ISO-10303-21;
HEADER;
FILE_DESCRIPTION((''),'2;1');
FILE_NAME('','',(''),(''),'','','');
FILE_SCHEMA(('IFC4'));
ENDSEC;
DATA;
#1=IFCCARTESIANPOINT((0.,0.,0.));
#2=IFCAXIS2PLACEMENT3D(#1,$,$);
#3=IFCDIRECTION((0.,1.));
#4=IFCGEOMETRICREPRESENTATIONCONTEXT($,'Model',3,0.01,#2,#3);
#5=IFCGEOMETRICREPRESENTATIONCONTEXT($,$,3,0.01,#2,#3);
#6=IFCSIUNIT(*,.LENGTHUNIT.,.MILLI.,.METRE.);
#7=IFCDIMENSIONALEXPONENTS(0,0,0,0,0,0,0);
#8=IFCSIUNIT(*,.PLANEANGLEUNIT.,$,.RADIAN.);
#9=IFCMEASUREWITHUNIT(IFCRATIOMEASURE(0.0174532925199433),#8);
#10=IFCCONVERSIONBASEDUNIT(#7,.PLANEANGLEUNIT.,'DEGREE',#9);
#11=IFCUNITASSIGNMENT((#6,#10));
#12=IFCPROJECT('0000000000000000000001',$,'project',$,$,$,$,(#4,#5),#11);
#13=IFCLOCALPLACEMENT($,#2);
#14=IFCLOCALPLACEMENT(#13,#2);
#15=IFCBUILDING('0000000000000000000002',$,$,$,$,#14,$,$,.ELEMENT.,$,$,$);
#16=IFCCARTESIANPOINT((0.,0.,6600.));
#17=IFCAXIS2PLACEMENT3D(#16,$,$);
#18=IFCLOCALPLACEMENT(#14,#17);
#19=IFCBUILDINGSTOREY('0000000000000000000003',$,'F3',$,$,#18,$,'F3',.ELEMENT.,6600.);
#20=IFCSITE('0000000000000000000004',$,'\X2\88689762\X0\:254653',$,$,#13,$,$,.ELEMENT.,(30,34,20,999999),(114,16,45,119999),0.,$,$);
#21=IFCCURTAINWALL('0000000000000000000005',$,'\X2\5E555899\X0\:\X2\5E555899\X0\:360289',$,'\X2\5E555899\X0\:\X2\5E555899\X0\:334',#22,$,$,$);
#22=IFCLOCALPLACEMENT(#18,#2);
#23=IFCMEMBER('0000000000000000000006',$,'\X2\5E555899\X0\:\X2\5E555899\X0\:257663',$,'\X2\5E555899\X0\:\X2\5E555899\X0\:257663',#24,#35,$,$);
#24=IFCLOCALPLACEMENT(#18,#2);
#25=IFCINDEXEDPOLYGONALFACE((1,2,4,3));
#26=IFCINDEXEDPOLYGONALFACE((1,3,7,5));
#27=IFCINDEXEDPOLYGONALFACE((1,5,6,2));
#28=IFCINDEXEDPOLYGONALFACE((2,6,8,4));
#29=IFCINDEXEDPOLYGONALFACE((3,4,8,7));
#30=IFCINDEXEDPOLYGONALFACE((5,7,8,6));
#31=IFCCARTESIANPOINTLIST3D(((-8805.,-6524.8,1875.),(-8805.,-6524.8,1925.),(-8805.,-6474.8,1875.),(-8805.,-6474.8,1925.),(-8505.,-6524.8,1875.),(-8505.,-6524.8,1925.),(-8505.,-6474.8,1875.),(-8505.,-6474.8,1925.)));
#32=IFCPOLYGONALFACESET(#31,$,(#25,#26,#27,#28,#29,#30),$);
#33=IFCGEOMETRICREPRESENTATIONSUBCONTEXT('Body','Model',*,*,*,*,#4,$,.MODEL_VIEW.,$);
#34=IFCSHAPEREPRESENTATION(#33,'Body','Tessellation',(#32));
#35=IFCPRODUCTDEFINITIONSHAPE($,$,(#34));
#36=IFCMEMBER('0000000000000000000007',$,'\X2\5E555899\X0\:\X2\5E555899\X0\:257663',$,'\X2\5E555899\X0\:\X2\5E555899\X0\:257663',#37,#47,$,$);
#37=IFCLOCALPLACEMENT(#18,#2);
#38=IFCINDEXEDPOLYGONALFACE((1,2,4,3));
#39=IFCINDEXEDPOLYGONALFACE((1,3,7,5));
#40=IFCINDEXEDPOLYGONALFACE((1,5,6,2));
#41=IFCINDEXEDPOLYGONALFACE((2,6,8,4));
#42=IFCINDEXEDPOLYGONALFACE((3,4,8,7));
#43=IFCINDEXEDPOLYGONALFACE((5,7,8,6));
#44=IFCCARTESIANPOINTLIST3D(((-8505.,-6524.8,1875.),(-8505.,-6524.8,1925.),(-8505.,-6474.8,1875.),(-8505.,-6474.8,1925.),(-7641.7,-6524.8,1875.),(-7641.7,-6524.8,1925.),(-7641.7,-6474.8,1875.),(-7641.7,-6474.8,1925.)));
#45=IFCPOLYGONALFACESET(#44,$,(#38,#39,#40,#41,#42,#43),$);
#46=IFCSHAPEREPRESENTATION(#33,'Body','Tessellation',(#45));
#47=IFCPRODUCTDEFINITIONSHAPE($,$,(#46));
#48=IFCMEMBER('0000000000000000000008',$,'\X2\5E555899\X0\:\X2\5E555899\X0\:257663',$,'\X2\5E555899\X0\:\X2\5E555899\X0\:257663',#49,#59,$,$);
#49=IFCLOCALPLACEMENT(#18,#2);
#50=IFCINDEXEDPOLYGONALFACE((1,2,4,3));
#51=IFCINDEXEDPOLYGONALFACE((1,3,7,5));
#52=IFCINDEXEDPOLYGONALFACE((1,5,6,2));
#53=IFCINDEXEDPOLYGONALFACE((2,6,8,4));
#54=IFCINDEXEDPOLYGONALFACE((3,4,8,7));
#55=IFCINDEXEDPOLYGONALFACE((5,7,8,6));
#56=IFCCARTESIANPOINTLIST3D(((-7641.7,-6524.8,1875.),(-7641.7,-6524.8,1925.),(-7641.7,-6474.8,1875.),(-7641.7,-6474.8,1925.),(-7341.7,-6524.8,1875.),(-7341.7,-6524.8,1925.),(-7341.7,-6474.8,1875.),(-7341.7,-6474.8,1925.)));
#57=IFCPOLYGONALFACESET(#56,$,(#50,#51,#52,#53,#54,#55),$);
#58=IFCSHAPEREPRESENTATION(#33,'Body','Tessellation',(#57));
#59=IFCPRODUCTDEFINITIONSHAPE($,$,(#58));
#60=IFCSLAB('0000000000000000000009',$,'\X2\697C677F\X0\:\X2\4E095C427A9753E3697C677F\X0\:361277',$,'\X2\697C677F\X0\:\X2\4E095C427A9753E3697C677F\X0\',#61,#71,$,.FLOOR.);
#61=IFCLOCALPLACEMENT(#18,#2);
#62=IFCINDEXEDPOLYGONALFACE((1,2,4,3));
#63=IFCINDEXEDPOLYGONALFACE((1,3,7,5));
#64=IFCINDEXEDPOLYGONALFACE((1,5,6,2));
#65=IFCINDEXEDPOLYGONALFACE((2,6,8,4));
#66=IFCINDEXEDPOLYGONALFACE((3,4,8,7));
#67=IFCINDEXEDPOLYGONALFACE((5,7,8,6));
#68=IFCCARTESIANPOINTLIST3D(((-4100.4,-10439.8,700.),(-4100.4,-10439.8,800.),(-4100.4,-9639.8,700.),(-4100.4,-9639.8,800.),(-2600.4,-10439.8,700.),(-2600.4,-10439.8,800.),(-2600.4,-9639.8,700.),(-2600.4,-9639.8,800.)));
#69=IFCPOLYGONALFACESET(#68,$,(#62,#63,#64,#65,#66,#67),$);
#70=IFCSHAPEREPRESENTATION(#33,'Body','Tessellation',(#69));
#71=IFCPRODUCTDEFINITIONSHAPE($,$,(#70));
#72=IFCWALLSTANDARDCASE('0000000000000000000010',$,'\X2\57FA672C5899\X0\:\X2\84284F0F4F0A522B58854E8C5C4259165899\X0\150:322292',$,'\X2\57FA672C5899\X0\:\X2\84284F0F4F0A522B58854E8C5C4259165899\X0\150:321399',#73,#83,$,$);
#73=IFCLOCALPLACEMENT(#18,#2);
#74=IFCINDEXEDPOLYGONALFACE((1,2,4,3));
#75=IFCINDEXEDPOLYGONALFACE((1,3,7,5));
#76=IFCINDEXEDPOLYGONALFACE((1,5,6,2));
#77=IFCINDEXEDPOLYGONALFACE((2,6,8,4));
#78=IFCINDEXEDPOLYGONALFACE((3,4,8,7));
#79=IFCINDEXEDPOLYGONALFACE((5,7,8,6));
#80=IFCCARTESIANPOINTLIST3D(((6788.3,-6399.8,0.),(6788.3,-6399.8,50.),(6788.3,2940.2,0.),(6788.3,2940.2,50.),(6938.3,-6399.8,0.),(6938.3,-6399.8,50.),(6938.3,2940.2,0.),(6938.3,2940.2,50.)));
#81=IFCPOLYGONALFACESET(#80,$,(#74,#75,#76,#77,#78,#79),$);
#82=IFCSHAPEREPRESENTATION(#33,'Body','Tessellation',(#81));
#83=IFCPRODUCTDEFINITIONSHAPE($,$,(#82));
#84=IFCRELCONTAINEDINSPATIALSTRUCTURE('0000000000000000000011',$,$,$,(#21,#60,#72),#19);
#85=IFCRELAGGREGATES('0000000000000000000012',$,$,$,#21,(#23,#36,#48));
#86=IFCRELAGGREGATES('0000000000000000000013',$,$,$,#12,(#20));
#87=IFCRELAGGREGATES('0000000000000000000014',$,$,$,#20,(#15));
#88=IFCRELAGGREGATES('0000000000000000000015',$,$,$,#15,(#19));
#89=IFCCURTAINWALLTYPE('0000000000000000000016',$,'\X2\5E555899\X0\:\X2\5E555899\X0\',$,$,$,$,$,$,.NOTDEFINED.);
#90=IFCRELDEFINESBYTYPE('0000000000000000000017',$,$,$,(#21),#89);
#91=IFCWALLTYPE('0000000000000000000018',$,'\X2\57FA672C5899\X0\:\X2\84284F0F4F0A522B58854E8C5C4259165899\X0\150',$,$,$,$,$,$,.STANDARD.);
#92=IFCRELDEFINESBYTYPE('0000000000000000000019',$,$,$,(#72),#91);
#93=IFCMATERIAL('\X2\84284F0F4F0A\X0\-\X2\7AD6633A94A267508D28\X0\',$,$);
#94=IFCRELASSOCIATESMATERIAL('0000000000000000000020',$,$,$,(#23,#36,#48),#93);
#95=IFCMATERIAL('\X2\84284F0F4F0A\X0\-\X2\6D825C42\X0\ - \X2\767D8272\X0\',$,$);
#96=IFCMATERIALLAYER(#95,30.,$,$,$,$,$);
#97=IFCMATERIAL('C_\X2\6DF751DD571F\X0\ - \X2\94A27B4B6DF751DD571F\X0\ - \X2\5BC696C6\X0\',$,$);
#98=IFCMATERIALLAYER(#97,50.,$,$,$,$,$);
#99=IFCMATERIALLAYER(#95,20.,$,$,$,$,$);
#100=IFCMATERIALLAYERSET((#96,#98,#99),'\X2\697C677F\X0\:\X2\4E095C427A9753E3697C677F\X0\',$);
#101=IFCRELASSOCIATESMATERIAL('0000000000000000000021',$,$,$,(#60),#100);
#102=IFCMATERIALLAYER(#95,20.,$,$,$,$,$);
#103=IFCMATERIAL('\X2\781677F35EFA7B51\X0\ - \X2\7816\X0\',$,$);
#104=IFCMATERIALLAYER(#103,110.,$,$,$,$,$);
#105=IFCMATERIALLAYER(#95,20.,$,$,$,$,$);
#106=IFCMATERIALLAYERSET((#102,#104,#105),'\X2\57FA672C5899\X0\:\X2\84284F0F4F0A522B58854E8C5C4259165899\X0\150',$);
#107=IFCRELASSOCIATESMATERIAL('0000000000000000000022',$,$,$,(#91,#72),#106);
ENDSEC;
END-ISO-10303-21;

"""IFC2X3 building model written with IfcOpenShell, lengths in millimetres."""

from ifc_helpers import new_model, entity, si_unit, converted_unit, direction, frame, frame_2d, origin, origin_2d_with_axis, place, context, subcontext, project, spatial, rectangle, extrude, material, layer, layer_set, layer_usage, type_object, element, aggregate, save


model = new_model("IFC2X3")

# Units and contexts
model_context = context("Model", 3, precision=0.01, world=origin(), true_north=direction((0.0, 1.0)))
context_of_model = context(None, 3, precision=0.01, world=origin(), true_north=direction((0.0, 1.0)))
body_context = subcontext(model_context, "Body", "Model", "MODEL_VIEW")
ifc_project = project(units=[si_unit("LENGTHUNIT", "METRE", prefix="MILLI"), converted_unit("PLANEANGLEUNIT", "DEGREE", entity("IfcRatioMeasure", 0.0174532925199433), si_unit("PLANEANGLEUNIT", "RADIAN"), dimensions=[0, 0, 0, 0, 0, 0, 0])], contexts=[model_context, context_of_model])

# Site, building, storey
site_placement = place(None, origin())
site = spatial("IfcSite", under=ifc_project, at=site_placement, Name="表面:254653", CompositionType="ELEMENT", RefLatitude=(30, 34, 20, 999999), RefLongitude=(114, 16, 45, 119999), RefElevation=0.0)
building_placement = place(site_placement, origin())
building = spatial("IfcBuilding", under=site, at=building_placement, CompositionType="ELEMENT")
storey_placement = place(building_placement, frame((0.0, 0.0, 6600.0)))
storey = spatial("IfcBuildingStorey", under=building, at=storey_placement, Name="F3", LongName="F3", CompositionType="ELEMENT", Elevation=6600.0)

# Shared definitions
ifc_material_1 = material(Name="萨伏伊-涂层 - 白色")

# Curtain wall, members
curtain_wall_type = type_object("IfcCurtainWallType", Name="幕墙:幕墙", PredefinedType="NOTDEFINED")
curtain_wall_placement = place(storey_placement, frame((0.0, 0.0, -6600.0)))
curtain_wall = element("IfcCurtainWall", 1, at=curtain_wall_placement, inside=storey, type_object=curtain_wall_type, Name="幕墙:幕墙:360289", ObjectType="幕墙:幕墙:334")
ifc_material_2 = material(Name="萨伏伊-竖挺钢材质")
member_1_placement = place(curtain_wall_placement, frame((0.0, 0.0, 6600.0)))
member_1 = element("IfcMember", 2, at=member_1_placement, material=ifc_material_2, Name="幕墙:幕墙:257663", ObjectType="幕墙:幕墙:257663", context=body_context, shape_type="SweptSolid", body=[
    extrude(rectangle(XDim=50.0, YDim=50.0, at=frame_2d((0.0, 0.0), x_axis=(1.0, 0.0))), frame((-8505.0, -6499.8, 1900.0), z_axis=(-1.0, 0.0, 0.0), x_axis=(0.0, 0.0, -1.0)), (0.0, 0.0, 1.0), 300.0),
])
member_2_placement = place(curtain_wall_placement, frame((0.0, 0.0, 6600.0)))
member_2 = element("IfcMember", 3, at=member_2_placement, material=ifc_material_2, Name="幕墙:幕墙:257663", ObjectType="幕墙:幕墙:257663", context=body_context, shape_type="SweptSolid", body=[
    extrude(rectangle(XDim=50.0, YDim=50.0, at=frame_2d((0.0, 0.0), x_axis=(1.0, 0.0))), frame((-7641.7, -6499.8, 1900.0), z_axis=(-1.0, 0.0, 0.0), x_axis=(0.0, 0.0, -1.0)), (0.0, 0.0, 1.0), 863.3),
])
member_3_placement = place(curtain_wall_placement, frame((0.0, 0.0, 6600.0)))
member_3 = element("IfcMember", 4, at=member_3_placement, material=ifc_material_2, Name="幕墙:幕墙:257663", ObjectType="幕墙:幕墙:257663", context=body_context, shape_type="SweptSolid", body=[
    extrude(rectangle(XDim=50.0, YDim=50.0, at=frame_2d((0.0, 0.0), x_axis=(1.0, 0.0))), frame((-7341.7, -6499.8, 1900.0), z_axis=(-1.0, 0.0, 0.0), x_axis=(0.0, 0.0, -1.0)), (0.0, 0.0, 1.0), 300.0),
])
aggregate(curtain_wall, [member_1, member_2, member_3])

# Slab
ifc_layer_1 = layer(ifc_material_1, 30.0)
ifc_material_3 = material(Name="C_混凝土 - 钢筋混凝土 - 密集")
ifc_layer_2 = layer(ifc_material_3, 50.0)
ifc_layer_3 = layer(ifc_material_1, 20.0)
ifc_layer_set_1 = layer_set([ifc_layer_1, ifc_layer_2, ifc_layer_3], Name="楼板:三层窗口楼板")
ifc_layer_usage_1 = layer_usage(ifc_layer_set_1, "AXIS3", "POSITIVE", 0.0)
slab_placement = place(storey_placement, origin())
element("IfcSlab", 5, at=slab_placement, inside=storey, material=ifc_layer_usage_1, Name="楼板:三层窗口楼板:361277", ObjectType="楼板:三层窗口楼板", PredefinedType="FLOOR", context=body_context, shape_type="SweptSolid", body=[
    extrude(rectangle(XDim=800.0, YDim=1500.0, at=origin_2d_with_axis()), frame((-3350.4, -10039.8, 800.0), z_axis=(0.0, 0.0, -1.0), x_axis=(0.0, 1.0, 0.0)), (0.0, 0.0, 1.0), 100.0),
])

# Wall
ifc_layer_4 = layer(ifc_material_1, 20.0)
ifc_material_4 = material(Name="砖石建筑 - 砖")
ifc_layer_5 = layer(ifc_material_4, 110.0)
ifc_layer_6 = layer(ifc_material_1, 20.0)
ifc_layer_set_2 = layer_set([ifc_layer_4, ifc_layer_5, ifc_layer_6], Name="基本墙:萨伏伊别墅二层外墙150")
ifc_layer_usage_2 = layer_usage(ifc_layer_set_2, "AXIS2", "NEGATIVE", 75.0)
wall_type = type_object("IfcWallType", Name="基本墙:萨伏伊别墅二层外墙150", PredefinedType="STANDARD", material=ifc_layer_set_2)
wall_placement = place(storey_placement, frame((6863.3, 2940.2, 0.0), z_axis=(0.0, 0.0, 1.0), x_axis=(0.0, -1.0, 0.0)))
element("IfcWallStandardCase", 6, at=wall_placement, inside=storey, type_object=wall_type, material=ifc_layer_usage_2, Name="基本墙:萨伏伊别墅二层外墙150:322292", ObjectType="基本墙:萨伏伊别墅二层外墙150:321399", context=body_context, shape_type="SweptSolid", body=[
    extrude(rectangle(XDim=9340.0, YDim=150.0, at=frame_2d((4670.0, 0.0), x_axis=(-1.0, 0.0))), origin(), (0.0, 0.0, 1.0), 50.0),
])

save(model, "model.ifc")
